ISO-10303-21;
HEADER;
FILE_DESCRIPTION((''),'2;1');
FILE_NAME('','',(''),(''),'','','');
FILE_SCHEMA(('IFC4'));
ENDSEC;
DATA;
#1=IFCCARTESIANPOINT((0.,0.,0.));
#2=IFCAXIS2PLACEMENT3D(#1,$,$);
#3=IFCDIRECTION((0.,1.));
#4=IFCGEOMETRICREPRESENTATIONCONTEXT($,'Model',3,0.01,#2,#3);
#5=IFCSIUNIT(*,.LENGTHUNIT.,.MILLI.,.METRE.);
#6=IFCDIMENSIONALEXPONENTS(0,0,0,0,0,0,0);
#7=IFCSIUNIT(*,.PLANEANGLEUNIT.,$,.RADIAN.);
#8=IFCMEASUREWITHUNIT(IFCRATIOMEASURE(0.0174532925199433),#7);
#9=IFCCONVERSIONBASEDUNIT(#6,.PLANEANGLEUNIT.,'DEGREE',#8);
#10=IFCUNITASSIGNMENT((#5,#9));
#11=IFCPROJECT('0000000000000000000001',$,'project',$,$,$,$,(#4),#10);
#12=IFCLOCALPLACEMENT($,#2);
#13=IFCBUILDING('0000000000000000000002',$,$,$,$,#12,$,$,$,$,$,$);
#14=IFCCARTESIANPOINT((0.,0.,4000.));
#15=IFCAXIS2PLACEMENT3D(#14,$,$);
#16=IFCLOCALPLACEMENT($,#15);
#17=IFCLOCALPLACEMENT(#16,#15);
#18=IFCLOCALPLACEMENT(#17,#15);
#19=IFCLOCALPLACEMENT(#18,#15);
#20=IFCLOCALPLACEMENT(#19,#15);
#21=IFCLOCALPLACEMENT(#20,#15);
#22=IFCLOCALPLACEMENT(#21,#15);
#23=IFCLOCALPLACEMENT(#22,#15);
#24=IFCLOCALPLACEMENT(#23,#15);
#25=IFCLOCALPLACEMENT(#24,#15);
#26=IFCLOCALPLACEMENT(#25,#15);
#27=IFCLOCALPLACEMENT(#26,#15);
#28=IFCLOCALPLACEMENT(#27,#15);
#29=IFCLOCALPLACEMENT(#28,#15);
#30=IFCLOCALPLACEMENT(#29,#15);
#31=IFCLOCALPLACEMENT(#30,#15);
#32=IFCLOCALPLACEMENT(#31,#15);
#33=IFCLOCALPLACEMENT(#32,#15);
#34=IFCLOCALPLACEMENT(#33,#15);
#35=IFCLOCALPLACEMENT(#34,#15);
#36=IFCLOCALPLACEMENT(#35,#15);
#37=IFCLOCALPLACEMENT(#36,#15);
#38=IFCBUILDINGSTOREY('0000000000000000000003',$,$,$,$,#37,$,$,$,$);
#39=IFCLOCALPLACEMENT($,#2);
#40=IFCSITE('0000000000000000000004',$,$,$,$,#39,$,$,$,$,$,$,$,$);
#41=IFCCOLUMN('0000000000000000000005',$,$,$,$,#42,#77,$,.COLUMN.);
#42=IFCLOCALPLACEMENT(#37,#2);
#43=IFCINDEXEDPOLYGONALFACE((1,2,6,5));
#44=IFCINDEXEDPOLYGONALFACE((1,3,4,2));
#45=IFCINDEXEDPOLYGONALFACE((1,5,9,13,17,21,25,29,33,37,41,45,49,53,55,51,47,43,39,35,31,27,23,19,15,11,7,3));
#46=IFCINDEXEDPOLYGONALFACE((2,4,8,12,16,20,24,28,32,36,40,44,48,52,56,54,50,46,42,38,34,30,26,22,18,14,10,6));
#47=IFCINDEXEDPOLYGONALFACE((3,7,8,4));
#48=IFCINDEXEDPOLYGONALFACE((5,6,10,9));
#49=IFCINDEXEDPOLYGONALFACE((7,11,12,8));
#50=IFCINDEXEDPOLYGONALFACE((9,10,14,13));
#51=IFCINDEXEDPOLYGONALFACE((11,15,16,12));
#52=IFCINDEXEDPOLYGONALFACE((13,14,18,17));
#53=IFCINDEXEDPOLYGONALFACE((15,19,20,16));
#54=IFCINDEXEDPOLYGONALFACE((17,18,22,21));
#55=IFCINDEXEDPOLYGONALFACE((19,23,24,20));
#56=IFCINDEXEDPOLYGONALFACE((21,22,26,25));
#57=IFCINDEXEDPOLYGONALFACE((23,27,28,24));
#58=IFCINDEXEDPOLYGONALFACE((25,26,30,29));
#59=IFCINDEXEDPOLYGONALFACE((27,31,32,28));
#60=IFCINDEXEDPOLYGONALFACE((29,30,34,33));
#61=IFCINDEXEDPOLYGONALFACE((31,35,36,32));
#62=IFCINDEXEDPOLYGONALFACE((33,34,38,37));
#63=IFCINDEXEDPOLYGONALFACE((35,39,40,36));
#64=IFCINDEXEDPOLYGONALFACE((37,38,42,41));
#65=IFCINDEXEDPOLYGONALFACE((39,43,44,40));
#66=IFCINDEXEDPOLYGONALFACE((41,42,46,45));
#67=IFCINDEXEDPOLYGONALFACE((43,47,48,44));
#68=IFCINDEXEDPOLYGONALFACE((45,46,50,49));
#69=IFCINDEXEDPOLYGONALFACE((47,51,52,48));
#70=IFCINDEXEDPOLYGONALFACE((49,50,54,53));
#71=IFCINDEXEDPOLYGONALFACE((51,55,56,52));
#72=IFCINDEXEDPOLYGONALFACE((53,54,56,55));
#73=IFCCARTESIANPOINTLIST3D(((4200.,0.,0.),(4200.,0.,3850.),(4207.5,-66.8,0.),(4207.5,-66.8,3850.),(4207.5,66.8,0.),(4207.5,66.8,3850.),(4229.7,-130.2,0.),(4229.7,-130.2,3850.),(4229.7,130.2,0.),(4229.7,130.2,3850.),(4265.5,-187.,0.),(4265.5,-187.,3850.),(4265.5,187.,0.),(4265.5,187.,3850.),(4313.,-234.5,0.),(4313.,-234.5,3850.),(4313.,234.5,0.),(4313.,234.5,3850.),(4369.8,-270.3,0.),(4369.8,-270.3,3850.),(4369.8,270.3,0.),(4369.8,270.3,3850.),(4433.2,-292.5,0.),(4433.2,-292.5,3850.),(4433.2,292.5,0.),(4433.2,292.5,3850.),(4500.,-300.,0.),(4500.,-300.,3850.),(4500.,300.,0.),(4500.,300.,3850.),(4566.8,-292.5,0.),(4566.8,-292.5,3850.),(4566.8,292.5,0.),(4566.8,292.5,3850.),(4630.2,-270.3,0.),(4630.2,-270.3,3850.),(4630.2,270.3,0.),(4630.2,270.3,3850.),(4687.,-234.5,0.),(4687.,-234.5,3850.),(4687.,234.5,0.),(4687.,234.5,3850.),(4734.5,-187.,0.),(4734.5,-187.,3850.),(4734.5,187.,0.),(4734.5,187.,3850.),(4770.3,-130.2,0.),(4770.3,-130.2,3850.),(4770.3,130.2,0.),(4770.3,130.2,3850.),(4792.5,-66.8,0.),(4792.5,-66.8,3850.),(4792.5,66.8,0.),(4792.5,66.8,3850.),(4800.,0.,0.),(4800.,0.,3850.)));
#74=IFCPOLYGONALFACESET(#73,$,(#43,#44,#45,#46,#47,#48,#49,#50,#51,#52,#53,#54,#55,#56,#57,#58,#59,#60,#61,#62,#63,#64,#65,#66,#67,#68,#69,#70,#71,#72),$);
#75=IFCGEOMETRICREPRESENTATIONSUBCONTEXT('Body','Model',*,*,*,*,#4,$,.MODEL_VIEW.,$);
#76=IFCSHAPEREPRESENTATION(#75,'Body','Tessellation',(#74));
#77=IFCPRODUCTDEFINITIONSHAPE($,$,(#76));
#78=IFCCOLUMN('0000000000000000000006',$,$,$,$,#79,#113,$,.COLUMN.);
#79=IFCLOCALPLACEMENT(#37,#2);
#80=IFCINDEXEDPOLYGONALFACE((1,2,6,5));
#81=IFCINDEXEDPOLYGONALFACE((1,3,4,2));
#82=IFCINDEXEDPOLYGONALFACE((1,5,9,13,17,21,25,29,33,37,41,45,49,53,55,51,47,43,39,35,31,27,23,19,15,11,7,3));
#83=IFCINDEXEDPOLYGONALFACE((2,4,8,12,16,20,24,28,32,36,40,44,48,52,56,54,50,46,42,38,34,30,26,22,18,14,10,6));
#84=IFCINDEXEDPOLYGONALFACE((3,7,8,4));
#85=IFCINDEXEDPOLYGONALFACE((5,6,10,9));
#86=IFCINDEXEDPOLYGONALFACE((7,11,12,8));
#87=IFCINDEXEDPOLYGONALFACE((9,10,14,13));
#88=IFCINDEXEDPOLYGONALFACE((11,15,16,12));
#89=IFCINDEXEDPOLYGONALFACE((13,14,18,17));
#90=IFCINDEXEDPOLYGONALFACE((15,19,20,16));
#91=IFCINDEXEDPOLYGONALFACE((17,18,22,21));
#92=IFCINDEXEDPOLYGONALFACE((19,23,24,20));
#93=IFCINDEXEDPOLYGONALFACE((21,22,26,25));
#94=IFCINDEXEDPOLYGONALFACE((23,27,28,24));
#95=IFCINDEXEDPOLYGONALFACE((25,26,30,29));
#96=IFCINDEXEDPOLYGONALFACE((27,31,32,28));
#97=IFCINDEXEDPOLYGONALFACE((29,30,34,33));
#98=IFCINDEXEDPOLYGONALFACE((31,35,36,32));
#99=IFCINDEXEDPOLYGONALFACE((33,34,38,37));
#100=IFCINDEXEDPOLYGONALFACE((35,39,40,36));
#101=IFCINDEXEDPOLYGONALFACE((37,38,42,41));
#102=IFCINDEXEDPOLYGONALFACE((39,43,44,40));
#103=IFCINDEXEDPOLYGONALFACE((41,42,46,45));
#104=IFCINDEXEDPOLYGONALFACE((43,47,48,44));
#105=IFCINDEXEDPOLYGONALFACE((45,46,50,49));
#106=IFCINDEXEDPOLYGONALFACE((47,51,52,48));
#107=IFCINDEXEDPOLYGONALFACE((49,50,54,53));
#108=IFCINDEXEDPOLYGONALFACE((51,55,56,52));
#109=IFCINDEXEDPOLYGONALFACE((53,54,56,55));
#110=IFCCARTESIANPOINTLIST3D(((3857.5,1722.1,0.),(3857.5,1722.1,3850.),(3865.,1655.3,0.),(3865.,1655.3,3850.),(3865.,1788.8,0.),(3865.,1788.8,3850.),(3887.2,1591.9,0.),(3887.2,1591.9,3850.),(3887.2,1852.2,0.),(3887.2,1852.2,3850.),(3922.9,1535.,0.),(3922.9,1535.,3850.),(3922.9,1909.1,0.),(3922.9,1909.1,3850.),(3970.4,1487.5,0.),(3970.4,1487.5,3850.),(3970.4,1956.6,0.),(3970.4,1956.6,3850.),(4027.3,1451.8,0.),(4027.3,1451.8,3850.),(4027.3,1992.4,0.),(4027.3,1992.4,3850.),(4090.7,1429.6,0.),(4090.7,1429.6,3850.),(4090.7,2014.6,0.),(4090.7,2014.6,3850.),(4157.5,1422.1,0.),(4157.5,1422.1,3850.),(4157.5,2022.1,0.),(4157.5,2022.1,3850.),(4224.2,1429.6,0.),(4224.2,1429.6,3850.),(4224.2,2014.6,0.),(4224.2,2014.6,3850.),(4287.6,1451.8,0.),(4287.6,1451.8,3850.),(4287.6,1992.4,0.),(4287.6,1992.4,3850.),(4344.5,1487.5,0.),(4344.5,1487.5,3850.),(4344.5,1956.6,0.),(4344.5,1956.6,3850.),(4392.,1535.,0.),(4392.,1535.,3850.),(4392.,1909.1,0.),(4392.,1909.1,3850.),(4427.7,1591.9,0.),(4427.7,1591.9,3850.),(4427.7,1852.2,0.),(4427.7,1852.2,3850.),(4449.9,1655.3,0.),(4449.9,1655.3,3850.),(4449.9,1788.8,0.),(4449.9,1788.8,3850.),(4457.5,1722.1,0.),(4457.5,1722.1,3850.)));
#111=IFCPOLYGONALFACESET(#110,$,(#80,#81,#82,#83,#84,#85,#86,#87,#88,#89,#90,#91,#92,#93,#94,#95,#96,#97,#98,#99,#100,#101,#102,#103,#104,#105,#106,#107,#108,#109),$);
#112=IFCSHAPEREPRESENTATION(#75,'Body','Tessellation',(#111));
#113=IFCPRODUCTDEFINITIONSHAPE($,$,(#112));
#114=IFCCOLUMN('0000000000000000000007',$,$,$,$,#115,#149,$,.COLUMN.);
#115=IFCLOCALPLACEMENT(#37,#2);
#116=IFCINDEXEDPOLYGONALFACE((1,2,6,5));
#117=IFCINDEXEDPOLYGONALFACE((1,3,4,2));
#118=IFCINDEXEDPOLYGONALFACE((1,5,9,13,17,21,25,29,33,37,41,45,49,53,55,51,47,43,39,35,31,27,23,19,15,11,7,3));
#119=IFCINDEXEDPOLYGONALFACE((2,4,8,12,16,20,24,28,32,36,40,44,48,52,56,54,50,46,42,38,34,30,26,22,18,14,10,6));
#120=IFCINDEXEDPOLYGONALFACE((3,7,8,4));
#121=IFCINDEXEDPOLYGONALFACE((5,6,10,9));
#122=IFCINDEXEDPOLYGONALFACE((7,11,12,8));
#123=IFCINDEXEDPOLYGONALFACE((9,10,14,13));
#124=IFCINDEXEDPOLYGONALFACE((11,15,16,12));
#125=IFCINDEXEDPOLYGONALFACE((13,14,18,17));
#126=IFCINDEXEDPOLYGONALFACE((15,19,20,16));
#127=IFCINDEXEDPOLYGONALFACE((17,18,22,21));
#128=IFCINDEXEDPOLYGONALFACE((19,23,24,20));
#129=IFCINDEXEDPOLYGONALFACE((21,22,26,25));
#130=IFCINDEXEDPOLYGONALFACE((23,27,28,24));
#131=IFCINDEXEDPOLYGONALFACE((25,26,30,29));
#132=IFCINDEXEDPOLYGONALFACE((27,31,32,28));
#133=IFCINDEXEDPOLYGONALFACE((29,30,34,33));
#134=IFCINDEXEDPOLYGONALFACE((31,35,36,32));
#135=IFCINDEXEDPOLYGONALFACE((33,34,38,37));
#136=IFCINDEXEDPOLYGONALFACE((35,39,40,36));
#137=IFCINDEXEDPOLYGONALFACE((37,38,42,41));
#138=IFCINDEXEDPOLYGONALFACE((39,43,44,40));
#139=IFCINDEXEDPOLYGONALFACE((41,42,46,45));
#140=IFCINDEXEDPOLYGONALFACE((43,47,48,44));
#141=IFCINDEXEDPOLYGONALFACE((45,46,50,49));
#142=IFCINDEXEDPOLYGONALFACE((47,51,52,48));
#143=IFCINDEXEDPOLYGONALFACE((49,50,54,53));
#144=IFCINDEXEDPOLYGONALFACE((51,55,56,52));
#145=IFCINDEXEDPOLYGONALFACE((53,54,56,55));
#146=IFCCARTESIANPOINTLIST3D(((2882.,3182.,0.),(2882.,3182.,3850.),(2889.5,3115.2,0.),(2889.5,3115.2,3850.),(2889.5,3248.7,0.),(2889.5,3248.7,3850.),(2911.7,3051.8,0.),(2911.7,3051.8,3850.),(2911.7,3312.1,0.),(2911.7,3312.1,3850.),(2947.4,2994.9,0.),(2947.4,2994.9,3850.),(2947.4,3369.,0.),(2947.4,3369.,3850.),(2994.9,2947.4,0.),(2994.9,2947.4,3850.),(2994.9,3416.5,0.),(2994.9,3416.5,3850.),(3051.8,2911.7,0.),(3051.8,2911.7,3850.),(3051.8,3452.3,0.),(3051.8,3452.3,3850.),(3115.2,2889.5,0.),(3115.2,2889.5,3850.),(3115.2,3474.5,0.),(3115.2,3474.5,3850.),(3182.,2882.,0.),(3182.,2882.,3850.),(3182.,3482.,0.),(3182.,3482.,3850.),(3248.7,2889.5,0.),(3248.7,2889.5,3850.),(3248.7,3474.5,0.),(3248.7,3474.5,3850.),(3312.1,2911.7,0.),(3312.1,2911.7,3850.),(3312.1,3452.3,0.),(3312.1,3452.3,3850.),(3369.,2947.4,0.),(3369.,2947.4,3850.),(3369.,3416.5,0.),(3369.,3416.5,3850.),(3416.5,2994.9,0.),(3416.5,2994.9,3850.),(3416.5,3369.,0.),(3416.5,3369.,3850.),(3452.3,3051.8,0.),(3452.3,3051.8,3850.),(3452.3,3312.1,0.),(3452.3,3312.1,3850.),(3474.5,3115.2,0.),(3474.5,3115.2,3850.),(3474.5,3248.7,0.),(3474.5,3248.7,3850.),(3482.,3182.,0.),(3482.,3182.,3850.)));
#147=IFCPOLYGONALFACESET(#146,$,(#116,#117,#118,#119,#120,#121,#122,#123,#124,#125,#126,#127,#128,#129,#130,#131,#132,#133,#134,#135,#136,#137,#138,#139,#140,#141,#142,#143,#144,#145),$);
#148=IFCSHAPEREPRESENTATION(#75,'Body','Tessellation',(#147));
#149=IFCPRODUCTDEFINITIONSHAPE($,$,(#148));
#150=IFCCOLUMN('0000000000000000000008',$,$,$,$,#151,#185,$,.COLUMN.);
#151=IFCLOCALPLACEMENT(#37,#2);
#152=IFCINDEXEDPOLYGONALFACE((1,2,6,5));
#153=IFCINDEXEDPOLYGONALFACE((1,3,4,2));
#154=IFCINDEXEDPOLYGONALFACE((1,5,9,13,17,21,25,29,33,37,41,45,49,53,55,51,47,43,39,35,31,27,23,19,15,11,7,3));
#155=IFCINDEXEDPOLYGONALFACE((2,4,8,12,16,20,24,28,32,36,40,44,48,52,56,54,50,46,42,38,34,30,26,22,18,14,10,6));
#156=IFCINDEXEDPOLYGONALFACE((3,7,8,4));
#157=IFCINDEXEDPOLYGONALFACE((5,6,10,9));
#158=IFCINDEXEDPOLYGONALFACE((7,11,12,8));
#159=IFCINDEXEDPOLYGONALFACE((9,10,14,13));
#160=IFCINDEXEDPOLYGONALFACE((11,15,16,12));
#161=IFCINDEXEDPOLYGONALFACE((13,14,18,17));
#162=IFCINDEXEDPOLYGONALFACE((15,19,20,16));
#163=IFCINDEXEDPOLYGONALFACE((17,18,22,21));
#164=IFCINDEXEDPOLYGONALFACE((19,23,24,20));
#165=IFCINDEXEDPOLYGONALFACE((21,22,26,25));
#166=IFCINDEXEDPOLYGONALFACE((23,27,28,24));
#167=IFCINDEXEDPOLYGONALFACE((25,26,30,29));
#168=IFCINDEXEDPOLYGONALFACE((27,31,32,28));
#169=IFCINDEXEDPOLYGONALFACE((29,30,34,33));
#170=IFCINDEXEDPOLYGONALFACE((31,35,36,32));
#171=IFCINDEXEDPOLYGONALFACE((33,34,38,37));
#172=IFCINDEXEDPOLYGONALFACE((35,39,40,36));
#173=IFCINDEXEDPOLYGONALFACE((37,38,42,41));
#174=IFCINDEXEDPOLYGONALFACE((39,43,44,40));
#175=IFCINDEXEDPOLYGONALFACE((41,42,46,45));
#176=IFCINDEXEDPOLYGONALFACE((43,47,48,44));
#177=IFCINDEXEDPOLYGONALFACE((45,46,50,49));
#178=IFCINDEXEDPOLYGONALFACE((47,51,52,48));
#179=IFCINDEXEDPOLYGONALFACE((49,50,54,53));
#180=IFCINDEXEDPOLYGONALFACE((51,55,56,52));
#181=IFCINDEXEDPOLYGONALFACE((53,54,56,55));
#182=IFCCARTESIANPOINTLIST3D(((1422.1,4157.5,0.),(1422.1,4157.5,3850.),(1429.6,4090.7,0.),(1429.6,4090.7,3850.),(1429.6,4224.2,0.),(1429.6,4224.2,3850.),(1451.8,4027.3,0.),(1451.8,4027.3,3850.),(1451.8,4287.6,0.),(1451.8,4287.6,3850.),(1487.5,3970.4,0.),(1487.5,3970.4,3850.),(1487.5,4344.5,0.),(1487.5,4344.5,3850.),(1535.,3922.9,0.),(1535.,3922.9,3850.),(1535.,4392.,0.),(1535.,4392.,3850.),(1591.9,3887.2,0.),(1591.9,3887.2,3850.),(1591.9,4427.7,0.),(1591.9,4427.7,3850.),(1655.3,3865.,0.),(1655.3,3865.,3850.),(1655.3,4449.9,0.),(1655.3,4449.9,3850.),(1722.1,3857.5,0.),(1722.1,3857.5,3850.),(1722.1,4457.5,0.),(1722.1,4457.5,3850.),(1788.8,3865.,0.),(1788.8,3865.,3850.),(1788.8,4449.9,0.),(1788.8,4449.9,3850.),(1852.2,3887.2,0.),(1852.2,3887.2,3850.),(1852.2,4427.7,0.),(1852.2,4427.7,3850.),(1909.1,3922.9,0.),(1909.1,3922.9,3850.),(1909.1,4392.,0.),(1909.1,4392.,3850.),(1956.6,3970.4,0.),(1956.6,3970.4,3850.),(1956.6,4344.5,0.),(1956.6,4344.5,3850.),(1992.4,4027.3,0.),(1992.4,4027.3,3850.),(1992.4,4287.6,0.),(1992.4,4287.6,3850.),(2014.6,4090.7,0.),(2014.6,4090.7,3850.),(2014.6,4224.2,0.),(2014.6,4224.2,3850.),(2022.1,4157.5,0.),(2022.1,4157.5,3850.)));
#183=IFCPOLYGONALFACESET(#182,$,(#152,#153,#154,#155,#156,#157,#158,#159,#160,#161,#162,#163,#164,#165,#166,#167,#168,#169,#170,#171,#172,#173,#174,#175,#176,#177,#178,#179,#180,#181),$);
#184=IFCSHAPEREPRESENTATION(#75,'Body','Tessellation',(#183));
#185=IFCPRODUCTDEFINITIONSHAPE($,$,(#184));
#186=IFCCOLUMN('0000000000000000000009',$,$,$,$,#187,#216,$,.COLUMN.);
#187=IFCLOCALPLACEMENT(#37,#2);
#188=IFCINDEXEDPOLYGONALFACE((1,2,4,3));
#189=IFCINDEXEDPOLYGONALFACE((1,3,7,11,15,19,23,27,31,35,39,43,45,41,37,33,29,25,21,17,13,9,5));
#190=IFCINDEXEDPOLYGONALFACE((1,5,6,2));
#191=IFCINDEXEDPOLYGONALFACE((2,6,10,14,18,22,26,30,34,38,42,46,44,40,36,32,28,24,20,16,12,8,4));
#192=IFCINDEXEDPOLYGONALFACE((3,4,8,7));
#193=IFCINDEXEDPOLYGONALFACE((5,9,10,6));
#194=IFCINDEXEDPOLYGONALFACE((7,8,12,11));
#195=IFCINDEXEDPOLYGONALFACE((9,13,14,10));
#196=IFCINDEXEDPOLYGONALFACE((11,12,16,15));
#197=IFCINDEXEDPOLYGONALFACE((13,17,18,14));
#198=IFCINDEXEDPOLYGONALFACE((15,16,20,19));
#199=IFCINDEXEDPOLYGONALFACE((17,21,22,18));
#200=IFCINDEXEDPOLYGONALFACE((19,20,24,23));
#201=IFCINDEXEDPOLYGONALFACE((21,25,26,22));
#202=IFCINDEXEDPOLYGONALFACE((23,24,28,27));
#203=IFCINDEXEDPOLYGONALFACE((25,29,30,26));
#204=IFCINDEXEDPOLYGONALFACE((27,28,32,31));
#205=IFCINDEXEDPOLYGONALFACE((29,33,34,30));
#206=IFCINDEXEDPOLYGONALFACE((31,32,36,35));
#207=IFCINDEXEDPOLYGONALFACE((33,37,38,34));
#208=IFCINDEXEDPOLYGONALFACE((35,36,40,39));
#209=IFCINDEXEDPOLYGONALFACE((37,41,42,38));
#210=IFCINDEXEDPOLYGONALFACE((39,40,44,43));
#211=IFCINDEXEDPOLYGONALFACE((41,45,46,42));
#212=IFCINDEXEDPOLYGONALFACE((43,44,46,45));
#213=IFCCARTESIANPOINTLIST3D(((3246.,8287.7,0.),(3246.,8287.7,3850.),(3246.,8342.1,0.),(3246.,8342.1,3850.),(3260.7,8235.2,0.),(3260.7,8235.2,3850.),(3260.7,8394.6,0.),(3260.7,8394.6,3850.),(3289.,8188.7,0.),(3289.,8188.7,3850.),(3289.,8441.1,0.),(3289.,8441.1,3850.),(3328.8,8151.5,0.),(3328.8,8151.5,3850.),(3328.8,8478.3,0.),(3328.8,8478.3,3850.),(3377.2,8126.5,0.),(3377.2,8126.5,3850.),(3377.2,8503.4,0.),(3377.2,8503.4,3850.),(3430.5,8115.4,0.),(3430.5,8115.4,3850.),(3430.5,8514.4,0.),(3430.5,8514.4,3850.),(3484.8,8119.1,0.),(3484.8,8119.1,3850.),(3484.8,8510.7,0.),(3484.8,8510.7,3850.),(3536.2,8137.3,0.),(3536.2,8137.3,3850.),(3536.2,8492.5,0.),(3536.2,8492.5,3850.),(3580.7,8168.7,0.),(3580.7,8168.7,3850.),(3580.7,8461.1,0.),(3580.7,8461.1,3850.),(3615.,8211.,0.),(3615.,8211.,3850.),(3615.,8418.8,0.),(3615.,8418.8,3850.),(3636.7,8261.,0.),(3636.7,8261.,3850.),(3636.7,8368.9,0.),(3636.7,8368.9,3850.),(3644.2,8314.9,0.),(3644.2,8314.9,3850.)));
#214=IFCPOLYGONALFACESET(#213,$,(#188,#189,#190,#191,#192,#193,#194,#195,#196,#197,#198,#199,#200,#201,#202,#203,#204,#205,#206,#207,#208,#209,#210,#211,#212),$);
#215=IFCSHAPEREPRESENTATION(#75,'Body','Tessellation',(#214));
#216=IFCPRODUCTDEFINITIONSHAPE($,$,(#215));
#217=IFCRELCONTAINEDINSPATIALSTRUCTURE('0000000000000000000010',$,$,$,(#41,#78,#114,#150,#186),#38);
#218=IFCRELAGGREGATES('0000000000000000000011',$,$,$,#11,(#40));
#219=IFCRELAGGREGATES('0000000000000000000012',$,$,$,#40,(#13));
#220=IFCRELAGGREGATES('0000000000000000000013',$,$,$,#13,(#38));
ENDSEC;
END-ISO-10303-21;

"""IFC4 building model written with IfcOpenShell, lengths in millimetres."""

from ifc_helpers import new_model, entity, si_unit, converted_unit, direction, frame, origin, origin_2d, place, context, subcontext, project, spatial, circle, extrude, element, save


model = new_model("IFC4")

# Units and contexts
model_context = context("Model", 3, precision=0.01, world=origin(), true_north=direction((0.0, 1.0)))
body_context = subcontext(model_context, "Body", "Model", "MODEL_VIEW")
ifc_project = project(units=[si_unit("LENGTHUNIT", "METRE", prefix="MILLI"), converted_unit("PLANEANGLEUNIT", "DEGREE", entity("IfcRatioMeasure", 0.0174532925199433), si_unit("PLANEANGLEUNIT", "RADIAN"), dimensions=[0, 0, 0, 0, 0, 0, 0])], contexts=[model_context])

# Site, building, storey
site_placement = place(None, origin())
site = spatial("IfcSite", under=ifc_project, at=site_placement)
building_placement = place(None, origin())
building = spatial("IfcBuilding", under=site, at=building_placement)
placement_1 = place(None, frame((0.0, 0.0, 4000.0)))
placement_2 = place(placement_1, frame((0.0, 0.0, 4000.0)))
placement_3 = place(placement_2, frame((0.0, 0.0, 4000.0)))
placement_4 = place(placement_3, frame((0.0, 0.0, 4000.0)))
placement_5 = place(placement_4, frame((0.0, 0.0, 4000.0)))
placement_6 = place(placement_5, frame((0.0, 0.0, 4000.0)))
placement_7 = place(placement_6, frame((0.0, 0.0, 4000.0)))
placement_8 = place(placement_7, frame((0.0, 0.0, 4000.0)))
placement_9 = place(placement_8, frame((0.0, 0.0, 4000.0)))
placement_10 = place(placement_9, frame((0.0, 0.0, 4000.0)))
placement_11 = place(placement_10, frame((0.0, 0.0, 4000.0)))
placement_12 = place(placement_11, frame((0.0, 0.0, 4000.0)))
placement_13 = place(placement_12, frame((0.0, 0.0, 4000.0)))
placement_14 = place(placement_13, frame((0.0, 0.0, 4000.0)))
placement_15 = place(placement_14, frame((0.0, 0.0, 4000.0)))
placement_16 = place(placement_15, frame((0.0, 0.0, 4000.0)))
placement_17 = place(placement_16, frame((0.0, 0.0, 4000.0)))
placement_18 = place(placement_17, frame((0.0, 0.0, 4000.0)))
placement_19 = place(placement_18, frame((0.0, 0.0, 4000.0)))
placement_20 = place(placement_19, frame((0.0, 0.0, 4000.0)))
placement_21 = place(placement_20, frame((0.0, 0.0, 4000.0)))
storey_placement = place(placement_21, frame((0.0, 0.0, 4000.0)))
storey = spatial("IfcBuildingStorey", under=building, at=storey_placement)

# Columns
for number, where in (
    (1, (4500.0, 0.0, 0.0)),
    (2, (4157.5, 1722.1, 0.0)),
    (3, (3182.0, 3182.0, 0.0)),
    (4, (1722.1, 4157.5, 0.0)),
):
    element("IfcColumn", number, at=place(storey_placement, frame(where)), inside=storey, PredefinedType="COLUMN", context=body_context, shape_type="SweptSolid", body=[
        extrude(circle(Radius=300.0, at=origin_2d()), origin(), (0.0, 0.0, 1.0), 3850.0),
    ])
column_placement = place(storey_placement, frame((3444.2, 8314.9, 0.0)))
element("IfcColumn", 5, at=column_placement, inside=storey, PredefinedType="COLUMN", context=body_context, shape_type="SweptSolid", body=[
    extrude(circle(Radius=200.0, at=origin_2d()), origin(), (0.0, 0.0, 1.0), 3850.0),
])

save(model, "model.ifc")
